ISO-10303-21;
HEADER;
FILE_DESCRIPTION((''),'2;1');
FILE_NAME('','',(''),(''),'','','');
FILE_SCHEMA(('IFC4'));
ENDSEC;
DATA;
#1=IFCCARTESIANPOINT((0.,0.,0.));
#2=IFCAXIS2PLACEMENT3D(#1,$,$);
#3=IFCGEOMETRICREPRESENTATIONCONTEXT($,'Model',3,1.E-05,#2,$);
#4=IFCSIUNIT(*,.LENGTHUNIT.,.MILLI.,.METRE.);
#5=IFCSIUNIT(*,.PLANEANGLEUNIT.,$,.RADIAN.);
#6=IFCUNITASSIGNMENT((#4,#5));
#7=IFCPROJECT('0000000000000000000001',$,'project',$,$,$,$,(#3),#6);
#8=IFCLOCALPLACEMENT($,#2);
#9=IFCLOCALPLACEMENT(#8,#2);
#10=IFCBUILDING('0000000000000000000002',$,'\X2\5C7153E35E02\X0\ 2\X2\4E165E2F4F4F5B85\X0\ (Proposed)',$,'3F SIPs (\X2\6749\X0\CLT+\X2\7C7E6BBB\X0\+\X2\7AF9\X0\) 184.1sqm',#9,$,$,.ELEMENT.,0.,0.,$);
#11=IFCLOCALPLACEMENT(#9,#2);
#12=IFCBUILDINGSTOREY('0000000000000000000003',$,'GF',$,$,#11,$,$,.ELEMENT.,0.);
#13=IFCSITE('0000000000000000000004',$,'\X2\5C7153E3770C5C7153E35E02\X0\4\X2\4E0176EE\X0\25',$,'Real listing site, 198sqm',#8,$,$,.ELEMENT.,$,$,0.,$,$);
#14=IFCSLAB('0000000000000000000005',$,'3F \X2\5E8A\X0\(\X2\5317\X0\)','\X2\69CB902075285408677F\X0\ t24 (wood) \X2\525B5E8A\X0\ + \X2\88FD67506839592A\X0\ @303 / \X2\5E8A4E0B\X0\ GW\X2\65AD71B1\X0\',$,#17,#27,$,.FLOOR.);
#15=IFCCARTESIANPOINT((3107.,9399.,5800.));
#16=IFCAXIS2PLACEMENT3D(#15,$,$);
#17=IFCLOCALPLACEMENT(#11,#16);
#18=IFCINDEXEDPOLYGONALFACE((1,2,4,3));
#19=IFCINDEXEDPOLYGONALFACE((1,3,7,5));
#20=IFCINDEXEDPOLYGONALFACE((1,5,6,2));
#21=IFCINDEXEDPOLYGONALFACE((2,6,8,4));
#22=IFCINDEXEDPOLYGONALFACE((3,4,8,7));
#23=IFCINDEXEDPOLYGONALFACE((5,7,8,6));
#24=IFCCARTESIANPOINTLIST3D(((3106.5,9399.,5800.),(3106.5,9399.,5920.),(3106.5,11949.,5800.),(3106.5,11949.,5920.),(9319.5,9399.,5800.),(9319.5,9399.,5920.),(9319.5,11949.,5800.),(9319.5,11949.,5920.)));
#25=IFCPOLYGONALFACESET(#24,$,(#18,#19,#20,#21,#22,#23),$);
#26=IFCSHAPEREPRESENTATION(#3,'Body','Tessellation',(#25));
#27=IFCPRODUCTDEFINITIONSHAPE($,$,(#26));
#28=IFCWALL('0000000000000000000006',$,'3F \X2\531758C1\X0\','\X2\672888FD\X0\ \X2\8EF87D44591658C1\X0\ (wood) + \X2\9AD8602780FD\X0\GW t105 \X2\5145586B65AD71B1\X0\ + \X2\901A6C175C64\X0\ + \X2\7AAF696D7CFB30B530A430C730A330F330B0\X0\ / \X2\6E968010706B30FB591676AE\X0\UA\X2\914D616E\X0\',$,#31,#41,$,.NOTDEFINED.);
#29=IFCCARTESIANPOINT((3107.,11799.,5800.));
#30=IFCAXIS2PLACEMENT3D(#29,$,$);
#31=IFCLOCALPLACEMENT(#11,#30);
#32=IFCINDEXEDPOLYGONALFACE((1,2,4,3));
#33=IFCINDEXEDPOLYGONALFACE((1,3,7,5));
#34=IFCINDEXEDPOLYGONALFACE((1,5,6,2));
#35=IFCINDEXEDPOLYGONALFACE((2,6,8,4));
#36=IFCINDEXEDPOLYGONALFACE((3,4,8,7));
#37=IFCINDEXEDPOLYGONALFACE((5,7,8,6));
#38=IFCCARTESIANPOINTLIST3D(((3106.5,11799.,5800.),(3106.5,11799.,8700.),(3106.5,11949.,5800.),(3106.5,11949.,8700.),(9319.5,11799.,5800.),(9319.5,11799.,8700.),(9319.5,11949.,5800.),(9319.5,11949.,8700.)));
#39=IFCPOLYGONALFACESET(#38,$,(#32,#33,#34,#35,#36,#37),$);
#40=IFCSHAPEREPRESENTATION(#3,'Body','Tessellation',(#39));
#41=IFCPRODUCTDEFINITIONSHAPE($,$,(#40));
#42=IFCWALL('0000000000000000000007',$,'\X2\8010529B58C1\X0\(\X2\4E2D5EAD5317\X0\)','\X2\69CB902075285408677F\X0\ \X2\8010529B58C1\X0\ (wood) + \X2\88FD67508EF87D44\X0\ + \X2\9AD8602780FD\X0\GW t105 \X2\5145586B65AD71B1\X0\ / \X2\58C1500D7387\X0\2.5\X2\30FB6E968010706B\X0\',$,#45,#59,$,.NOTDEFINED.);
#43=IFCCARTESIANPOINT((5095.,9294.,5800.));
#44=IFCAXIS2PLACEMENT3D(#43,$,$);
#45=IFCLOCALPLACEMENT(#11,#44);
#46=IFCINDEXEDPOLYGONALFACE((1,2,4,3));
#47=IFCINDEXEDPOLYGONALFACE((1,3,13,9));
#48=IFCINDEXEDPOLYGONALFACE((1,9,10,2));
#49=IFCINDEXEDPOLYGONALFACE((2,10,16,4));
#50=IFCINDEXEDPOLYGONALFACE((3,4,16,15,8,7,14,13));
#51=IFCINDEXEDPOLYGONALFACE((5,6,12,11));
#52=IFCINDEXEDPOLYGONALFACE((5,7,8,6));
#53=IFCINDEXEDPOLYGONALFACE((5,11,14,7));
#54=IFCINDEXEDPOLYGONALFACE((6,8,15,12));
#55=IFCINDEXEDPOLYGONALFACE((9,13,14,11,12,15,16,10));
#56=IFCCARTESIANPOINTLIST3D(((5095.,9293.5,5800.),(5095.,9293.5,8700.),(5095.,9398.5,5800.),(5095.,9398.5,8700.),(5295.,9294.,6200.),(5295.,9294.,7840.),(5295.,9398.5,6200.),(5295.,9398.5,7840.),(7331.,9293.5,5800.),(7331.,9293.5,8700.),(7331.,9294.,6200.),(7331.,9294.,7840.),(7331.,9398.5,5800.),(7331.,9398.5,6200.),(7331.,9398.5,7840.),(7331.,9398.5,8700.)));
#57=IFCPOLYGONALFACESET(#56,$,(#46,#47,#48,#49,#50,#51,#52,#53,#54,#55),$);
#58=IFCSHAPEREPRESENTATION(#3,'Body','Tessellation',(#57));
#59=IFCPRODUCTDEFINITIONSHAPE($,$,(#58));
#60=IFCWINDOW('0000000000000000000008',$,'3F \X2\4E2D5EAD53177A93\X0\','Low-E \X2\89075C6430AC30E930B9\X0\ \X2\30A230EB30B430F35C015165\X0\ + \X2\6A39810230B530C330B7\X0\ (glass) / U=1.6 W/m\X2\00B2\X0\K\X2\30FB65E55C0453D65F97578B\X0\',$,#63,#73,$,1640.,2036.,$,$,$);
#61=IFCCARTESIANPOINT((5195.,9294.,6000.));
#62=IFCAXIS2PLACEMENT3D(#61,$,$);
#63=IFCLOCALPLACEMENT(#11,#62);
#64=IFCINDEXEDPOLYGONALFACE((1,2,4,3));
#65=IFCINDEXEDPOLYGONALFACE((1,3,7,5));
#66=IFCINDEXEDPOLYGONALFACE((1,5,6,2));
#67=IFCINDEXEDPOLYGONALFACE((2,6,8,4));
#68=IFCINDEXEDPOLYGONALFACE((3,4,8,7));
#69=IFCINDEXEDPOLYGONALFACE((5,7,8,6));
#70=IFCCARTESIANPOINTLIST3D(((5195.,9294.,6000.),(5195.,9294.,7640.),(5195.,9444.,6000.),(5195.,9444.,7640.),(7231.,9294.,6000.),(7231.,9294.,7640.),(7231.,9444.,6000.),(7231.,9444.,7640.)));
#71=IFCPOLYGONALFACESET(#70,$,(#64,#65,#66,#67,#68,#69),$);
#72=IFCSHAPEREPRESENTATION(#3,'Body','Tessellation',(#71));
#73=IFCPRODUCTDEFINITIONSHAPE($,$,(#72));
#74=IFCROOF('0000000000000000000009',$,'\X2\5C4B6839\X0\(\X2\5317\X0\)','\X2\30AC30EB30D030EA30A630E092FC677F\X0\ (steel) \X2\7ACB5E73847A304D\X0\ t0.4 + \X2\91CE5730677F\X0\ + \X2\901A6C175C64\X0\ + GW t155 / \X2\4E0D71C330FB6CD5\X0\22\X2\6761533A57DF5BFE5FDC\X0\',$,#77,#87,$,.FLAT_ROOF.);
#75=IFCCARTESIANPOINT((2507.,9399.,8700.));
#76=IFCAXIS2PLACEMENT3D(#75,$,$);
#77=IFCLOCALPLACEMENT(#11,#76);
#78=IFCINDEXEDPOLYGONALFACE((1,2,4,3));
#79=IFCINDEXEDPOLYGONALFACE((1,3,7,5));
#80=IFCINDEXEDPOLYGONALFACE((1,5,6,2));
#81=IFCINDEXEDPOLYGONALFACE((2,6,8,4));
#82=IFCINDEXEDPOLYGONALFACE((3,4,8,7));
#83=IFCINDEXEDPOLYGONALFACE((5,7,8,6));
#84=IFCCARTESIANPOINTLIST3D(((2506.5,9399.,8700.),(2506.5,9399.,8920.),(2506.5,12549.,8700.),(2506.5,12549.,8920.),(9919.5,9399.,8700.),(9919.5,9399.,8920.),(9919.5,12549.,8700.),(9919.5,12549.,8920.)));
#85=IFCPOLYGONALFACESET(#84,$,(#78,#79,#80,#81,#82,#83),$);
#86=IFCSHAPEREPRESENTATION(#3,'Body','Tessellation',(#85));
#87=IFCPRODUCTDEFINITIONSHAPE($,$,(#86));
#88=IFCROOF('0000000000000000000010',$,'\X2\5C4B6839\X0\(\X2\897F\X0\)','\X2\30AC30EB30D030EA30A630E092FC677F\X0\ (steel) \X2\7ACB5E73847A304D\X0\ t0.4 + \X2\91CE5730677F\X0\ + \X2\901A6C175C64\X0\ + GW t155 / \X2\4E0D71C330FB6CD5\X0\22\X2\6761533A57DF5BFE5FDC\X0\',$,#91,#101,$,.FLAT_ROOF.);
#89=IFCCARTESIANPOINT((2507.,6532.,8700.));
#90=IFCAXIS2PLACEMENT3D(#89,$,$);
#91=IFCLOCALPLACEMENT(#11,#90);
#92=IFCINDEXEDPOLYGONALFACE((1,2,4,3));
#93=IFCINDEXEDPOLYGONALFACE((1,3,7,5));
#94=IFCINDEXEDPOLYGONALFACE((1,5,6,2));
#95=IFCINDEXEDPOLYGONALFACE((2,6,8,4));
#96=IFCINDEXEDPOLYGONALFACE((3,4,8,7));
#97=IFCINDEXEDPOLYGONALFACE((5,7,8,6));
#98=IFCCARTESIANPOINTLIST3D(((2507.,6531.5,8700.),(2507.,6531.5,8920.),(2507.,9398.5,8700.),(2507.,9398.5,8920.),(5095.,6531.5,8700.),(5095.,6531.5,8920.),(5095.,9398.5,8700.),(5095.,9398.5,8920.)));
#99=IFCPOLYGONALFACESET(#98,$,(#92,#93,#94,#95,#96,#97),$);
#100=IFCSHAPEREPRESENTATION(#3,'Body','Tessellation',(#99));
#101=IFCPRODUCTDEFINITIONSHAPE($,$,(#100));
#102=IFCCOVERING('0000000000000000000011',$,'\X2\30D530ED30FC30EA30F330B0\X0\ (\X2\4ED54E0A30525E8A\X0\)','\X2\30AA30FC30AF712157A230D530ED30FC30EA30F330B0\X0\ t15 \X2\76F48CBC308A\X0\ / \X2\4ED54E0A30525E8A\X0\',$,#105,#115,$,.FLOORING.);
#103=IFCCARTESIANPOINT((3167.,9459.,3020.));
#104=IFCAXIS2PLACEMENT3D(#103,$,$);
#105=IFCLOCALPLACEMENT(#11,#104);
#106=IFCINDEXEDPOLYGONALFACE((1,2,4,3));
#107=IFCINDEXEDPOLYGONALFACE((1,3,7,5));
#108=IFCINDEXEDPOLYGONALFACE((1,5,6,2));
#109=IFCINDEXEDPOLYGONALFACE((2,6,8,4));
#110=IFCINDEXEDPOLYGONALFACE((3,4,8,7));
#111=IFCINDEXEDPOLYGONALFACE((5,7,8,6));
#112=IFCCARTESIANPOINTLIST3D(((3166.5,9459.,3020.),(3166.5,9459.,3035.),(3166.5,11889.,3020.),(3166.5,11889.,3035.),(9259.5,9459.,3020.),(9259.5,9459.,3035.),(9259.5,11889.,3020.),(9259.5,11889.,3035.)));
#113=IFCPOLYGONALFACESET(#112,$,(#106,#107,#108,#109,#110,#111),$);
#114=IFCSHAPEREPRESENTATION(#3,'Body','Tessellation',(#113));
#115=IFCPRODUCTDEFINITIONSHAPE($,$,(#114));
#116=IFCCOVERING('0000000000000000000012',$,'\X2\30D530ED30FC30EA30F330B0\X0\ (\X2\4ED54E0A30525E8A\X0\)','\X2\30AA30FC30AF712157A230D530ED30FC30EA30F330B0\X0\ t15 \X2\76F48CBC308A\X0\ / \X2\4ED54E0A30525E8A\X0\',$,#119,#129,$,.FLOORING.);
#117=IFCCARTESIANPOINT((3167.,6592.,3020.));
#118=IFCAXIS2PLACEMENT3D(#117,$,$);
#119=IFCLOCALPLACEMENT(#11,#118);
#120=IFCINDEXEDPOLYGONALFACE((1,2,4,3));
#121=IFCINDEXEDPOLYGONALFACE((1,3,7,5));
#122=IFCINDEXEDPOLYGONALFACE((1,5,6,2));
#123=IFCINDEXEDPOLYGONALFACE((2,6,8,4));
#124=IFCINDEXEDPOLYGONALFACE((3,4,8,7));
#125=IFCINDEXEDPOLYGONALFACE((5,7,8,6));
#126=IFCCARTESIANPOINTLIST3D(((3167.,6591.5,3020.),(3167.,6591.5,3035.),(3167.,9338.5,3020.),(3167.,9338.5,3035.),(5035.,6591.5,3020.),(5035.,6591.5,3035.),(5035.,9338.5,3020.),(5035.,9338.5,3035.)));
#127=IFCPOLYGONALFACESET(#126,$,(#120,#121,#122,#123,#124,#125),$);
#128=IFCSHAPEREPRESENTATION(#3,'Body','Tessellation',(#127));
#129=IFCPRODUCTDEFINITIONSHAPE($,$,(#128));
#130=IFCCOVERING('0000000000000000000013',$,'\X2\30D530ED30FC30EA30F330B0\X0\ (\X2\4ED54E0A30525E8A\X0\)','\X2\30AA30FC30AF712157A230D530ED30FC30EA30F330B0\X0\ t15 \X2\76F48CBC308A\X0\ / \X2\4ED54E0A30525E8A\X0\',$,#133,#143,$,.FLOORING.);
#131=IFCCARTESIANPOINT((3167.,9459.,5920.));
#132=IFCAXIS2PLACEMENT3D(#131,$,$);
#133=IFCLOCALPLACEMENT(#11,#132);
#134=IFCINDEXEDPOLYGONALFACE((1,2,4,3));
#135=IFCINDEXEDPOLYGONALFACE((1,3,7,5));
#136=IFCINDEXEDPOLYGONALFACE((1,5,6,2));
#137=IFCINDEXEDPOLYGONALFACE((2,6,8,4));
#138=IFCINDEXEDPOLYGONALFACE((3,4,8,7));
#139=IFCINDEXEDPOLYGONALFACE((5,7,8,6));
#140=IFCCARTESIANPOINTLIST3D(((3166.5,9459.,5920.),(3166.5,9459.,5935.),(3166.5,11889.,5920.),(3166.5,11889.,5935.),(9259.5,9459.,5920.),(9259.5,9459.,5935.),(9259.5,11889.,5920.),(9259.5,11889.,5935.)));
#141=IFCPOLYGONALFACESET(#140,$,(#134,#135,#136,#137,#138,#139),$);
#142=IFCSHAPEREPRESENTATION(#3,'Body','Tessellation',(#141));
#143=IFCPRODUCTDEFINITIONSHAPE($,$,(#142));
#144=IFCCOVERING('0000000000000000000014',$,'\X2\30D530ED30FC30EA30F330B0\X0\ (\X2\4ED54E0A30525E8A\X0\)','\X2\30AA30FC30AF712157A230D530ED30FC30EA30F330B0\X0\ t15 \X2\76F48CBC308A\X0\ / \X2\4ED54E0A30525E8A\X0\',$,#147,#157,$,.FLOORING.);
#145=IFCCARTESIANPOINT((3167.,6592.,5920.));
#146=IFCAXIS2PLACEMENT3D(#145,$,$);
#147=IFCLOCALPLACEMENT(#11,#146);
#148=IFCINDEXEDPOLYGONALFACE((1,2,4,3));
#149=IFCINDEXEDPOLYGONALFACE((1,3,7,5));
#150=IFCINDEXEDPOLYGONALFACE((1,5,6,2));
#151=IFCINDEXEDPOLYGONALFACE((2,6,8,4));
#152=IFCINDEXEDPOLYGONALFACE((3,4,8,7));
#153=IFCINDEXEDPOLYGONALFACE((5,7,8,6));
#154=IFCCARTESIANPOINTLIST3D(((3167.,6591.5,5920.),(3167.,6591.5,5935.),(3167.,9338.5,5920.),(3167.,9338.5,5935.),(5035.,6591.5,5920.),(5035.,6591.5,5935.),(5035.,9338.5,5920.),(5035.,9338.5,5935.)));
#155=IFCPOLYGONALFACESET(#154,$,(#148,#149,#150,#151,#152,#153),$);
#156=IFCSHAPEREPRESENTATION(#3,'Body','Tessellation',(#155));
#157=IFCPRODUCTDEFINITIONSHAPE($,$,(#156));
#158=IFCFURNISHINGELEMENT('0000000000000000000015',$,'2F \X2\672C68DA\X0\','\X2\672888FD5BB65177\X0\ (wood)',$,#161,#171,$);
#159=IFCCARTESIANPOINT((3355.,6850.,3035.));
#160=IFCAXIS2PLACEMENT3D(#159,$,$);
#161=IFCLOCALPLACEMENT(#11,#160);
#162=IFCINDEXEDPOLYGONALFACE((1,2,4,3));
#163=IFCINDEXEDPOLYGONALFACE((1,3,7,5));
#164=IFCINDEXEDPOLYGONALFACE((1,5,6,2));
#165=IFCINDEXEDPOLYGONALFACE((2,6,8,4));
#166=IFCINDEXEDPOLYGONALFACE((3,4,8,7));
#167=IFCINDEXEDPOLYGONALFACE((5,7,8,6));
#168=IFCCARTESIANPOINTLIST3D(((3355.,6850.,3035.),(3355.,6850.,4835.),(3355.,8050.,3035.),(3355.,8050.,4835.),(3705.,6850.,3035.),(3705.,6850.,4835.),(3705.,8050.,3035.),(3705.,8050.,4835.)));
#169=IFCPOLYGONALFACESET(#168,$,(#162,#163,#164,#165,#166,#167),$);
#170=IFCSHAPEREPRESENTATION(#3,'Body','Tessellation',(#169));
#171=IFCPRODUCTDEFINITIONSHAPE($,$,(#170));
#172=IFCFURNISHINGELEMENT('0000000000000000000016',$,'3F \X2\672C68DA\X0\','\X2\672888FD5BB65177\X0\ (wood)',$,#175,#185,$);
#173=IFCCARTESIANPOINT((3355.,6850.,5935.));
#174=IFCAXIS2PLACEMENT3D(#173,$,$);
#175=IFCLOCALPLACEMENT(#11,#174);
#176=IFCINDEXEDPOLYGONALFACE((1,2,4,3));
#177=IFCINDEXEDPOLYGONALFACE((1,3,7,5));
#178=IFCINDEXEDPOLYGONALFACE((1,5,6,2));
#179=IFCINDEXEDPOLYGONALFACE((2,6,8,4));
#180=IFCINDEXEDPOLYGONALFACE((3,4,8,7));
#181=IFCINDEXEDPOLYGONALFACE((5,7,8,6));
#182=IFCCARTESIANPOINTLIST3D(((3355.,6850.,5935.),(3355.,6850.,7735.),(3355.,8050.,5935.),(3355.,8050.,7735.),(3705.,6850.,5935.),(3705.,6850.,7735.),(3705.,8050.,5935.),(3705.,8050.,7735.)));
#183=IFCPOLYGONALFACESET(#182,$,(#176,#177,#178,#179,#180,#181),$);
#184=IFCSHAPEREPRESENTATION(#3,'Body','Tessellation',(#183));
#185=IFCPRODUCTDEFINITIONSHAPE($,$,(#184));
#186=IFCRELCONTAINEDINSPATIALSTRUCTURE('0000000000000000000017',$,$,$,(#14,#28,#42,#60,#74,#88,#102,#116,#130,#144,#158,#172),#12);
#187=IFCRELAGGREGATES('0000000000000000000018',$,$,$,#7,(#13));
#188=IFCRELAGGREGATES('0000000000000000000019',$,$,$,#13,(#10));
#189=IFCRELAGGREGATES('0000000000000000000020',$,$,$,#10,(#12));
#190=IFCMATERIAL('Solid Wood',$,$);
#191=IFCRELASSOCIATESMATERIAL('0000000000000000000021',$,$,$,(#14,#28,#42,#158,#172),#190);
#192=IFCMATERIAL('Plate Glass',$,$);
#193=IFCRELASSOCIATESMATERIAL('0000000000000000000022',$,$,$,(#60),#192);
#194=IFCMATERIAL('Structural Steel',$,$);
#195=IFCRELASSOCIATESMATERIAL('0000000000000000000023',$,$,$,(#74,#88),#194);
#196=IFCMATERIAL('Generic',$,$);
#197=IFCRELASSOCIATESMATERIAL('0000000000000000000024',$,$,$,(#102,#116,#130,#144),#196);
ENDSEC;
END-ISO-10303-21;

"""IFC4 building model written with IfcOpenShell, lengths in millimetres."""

from ifc_helpers import new_model, si_unit, frame, frame_2d, origin, place, context, project, spatial, rectangle, extrude, material, element, fill, save


model = new_model("IFC4")

# Units and contexts
model_context = context("Model", 3, precision=1e-05, world=origin())
ifc_project = project(units=[si_unit("LENGTHUNIT", "METRE", prefix="MILLI"), si_unit("PLANEANGLEUNIT", "RADIAN")], contexts=[model_context])

# Site, building, storey
site_placement = place(None, origin())
site = spatial("IfcSite", under=ifc_project, at=site_placement, Name="山口県山口市4丁目25", ObjectType="Real listing site, 198sqm", CompositionType="ELEMENT", RefElevation=0.0)
building_placement = place(site_placement, origin())
building = spatial("IfcBuilding", under=site, at=building_placement, Name="山口市 2世帯住宅 (Proposed)", ObjectType="3F SIPs (杉CLT+籾殻+竹) 184.1sqm", CompositionType="ELEMENT", ElevationOfRefHeight=0.0, ElevationOfTerrain=0.0)
storey_placement = place(building_placement, origin())
storey = spatial("IfcBuildingStorey", under=building, at=storey_placement, Name="GF", CompositionType="ELEMENT", Elevation=0.0)

# Slab
ifc_material_1 = material(Name="Solid Wood")
slab_placement = place(storey_placement, frame((3107.0, 9399.0, 5800.0)))
element("IfcSlab", 1, at=slab_placement, inside=storey, material=ifc_material_1, Name="3F 床(北)", Description="構造用合板 t24 (wood) 剛床 + 製材根太 @303 / 床下 GW断熱", PredefinedType="FLOOR", context=model_context, shape_type="SweptSolid", body=[
    extrude(rectangle(XDim=6213.0, YDim=2550.0, at=frame_2d((3106.0, 1275.0))), frame((3107.0, 9399.0, 5800.0)), (0.0, 0.0, 1.0), 120.0),
])

# Wall
wall_1_placement = place(storey_placement, frame((3107.0, 11799.0, 5800.0)))
element("IfcWall", 2, at=wall_1_placement, inside=storey, material=ifc_material_1, Name="3F 北壁", Description="木製 軸組外壁 (wood) + 高性能GW t105 充填断熱 + 通気層 + 窯業系サイディング / 準耐火・外皮UA配慮", PredefinedType="NOTDEFINED", context=model_context, shape_type="SweptSolid", body=[
    extrude(rectangle(XDim=6213.0, YDim=150.0, at=frame_2d((3106.0, 75.0))), frame((3107.0, 11799.0, 5800.0)), (0.0, 0.0, 1.0), 2900.0),
])

# Wall, opening, window
wall_2_placement = place(storey_placement, frame((5095.0, 9294.0, 5800.0)))
wall_2 = element("IfcWall", 3, at=wall_2_placement, inside=storey, material=ifc_material_1, Name="耐力壁(中庭北)", Description="構造用合板 耐力壁 (wood) + 製材軸組 + 高性能GW t105 充填断熱 / 壁倍率2.5・準耐火", PredefinedType="NOTDEFINED", context=model_context, shape_type="SweptSolid", body=[
    extrude(rectangle(XDim=2236.0, YDim=105.0, at=frame_2d((1118.0, 52.0))), frame((5095.0, 9294.0, 5800.0)), (0.0, 0.0, 1.0), 2900.0),
])
opening_placement = place(storey_placement, frame((5195.0, 9294.0, 6000.0)))
opening = element("IfcOpeningElement", 4, at=opening_placement, cuts=wall_2, PredefinedType="NOTDEFINED", context=model_context, shape_type="SweptSolid", body=[
    extrude(rectangle(XDim=2036.0, YDim=150.0, at=frame_2d((1018.0, 75.0))), frame((5195.0, 9294.0, 6000.0)), (0.0, 0.0, 1.0), 1640.0),
])
ifc_material_2 = material(Name="Plate Glass")
window_1_placement = place(storey_placement, frame((5195.0, 9294.0, 6000.0)))
window_1 = element("IfcWindow", 5, at=window_1_placement, inside=storey, material=ifc_material_2, Name="3F 中庭北窓", Description="Low-E 複層ガラス アルゴン封入 + 樹脂サッシ (glass) / U=1.6 W/m²K・日射取得型", OverallHeight=1640.0, OverallWidth=2036.0, context=model_context, shape_type="SweptSolid", body=[
    extrude(rectangle(XDim=2036.0, YDim=150.0, at=frame_2d((1018.0, 75.0))), frame((5195.0, 9294.0, 6000.0)), (0.0, 0.0, 1.0), 1640.0),
])
fill(opening, window_1)

# Shared definitions
ifc_material_3 = material(Name="Generic")

# Roofs
ifc_material_4 = material(Name="Structural Steel")
roof_1_placement = place(storey_placement, frame((2507.0, 9399.0, 8700.0)))
element("IfcRoof", 6, at=roof_1_placement, inside=storey, material=ifc_material_4, Name="屋根(北)", Description="ガルバリウム鋼板 (steel) 立平葺き t0.4 + 野地板 + 通気層 + GW t155 / 不燃・法22条区域対応", PredefinedType="FLAT_ROOF", context=model_context, shape_type="SweptSolid", body=[
    extrude(rectangle(XDim=7413.0, YDim=3150.0, at=frame_2d((3706.0, 1575.0))), frame((2507.0, 9399.0, 8700.0)), (0.0, 0.0, 1.0), 220.0),
])
roof_2_placement = place(storey_placement, frame((2507.0, 6532.0, 8700.0)))
element("IfcRoof", 7, at=roof_2_placement, inside=storey, material=ifc_material_4, Name="屋根(西)", Description="ガルバリウム鋼板 (steel) 立平葺き t0.4 + 野地板 + 通気層 + GW t155 / 不燃・法22条区域対応", PredefinedType="FLAT_ROOF", context=model_context, shape_type="SweptSolid", body=[
    extrude(rectangle(XDim=2588.0, YDim=2867.0, at=frame_2d((1294.0, 1433.0))), frame((2507.0, 6532.0, 8700.0)), (0.0, 0.0, 1.0), 220.0),
])

# Coverings
covering_1_placement = place(storey_placement, frame((3167.0, 9459.0, 3020.0)))
element("IfcCovering", 8, at=covering_1_placement, inside=storey, material=ifc_material_3, Name="フローリング (仕上げ床)", Description="オーク無垢フローリング t15 直貼り / 仕上げ床", PredefinedType="FLOORING", context=model_context, shape_type="SweptSolid", body=[
    extrude(rectangle(XDim=6093.0, YDim=2430.0, at=frame_2d((3046.0, 1215.0))), frame((3167.0, 9459.0, 3020.0)), (0.0, 0.0, 1.0), 15.0),
])
covering_2_placement = place(storey_placement, frame((3167.0, 6592.0, 3020.0)))
element("IfcCovering", 9, at=covering_2_placement, inside=storey, material=ifc_material_3, Name="フローリング (仕上げ床)", Description="オーク無垢フローリング t15 直貼り / 仕上げ床", PredefinedType="FLOORING", context=model_context, shape_type="SweptSolid", body=[
    extrude(rectangle(XDim=1868.0, YDim=2747.0, at=frame_2d((934.0, 1373.0))), frame((3167.0, 6592.0, 3020.0)), (0.0, 0.0, 1.0), 15.0),
])
covering_3_placement = place(storey_placement, frame((3167.0, 9459.0, 5920.0)))
element("IfcCovering", 10, at=covering_3_placement, inside=storey, material=ifc_material_3, Name="フローリング (仕上げ床)", Description="オーク無垢フローリング t15 直貼り / 仕上げ床", PredefinedType="FLOORING", context=model_context, shape_type="SweptSolid", body=[
    extrude(rectangle(XDim=6093.0, YDim=2430.0, at=frame_2d((3046.0, 1215.0))), frame((3167.0, 9459.0, 5920.0)), (0.0, 0.0, 1.0), 15.0),
])
covering_4_placement = place(storey_placement, frame((3167.0, 6592.0, 5920.0)))
element("IfcCovering", 11, at=covering_4_placement, inside=storey, material=ifc_material_3, Name="フローリング (仕上げ床)", Description="オーク無垢フローリング t15 直貼り / 仕上げ床", PredefinedType="FLOORING", context=model_context, shape_type="SweptSolid", body=[
    extrude(rectangle(XDim=1868.0, YDim=2747.0, at=frame_2d((934.0, 1373.0))), frame((3167.0, 6592.0, 5920.0)), (0.0, 0.0, 1.0), 15.0),
])

# Furnishing elements
furnishing_1_placement = place(storey_placement, frame((3355.0, 6850.0, 3035.0)))
element("IfcFurnishingElement", 12, at=furnishing_1_placement, inside=storey, material=ifc_material_1, Name="2F 本棚", Description="木製家具 (wood)", context=model_context, shape_type="SweptSolid", body=[
    extrude(rectangle(XDim=350.0, YDim=1200.0, at=frame_2d((175.0, 600.0))), frame((3355.0, 6850.0, 3035.0)), (0.0, 0.0, 1.0), 1800.0),
])
furnishing_2_placement = place(storey_placement, frame((3355.0, 6850.0, 5935.0)))
element("IfcFurnishingElement", 13, at=furnishing_2_placement, inside=storey, material=ifc_material_1, Name="3F 本棚", Description="木製家具 (wood)", context=model_context, shape_type="SweptSolid", body=[
    extrude(rectangle(XDim=350.0, YDim=1200.0, at=frame_2d((175.0, 600.0))), frame((3355.0, 6850.0, 5935.0)), (0.0, 0.0, 1.0), 1800.0),
])

save(model, "model.ifc")
